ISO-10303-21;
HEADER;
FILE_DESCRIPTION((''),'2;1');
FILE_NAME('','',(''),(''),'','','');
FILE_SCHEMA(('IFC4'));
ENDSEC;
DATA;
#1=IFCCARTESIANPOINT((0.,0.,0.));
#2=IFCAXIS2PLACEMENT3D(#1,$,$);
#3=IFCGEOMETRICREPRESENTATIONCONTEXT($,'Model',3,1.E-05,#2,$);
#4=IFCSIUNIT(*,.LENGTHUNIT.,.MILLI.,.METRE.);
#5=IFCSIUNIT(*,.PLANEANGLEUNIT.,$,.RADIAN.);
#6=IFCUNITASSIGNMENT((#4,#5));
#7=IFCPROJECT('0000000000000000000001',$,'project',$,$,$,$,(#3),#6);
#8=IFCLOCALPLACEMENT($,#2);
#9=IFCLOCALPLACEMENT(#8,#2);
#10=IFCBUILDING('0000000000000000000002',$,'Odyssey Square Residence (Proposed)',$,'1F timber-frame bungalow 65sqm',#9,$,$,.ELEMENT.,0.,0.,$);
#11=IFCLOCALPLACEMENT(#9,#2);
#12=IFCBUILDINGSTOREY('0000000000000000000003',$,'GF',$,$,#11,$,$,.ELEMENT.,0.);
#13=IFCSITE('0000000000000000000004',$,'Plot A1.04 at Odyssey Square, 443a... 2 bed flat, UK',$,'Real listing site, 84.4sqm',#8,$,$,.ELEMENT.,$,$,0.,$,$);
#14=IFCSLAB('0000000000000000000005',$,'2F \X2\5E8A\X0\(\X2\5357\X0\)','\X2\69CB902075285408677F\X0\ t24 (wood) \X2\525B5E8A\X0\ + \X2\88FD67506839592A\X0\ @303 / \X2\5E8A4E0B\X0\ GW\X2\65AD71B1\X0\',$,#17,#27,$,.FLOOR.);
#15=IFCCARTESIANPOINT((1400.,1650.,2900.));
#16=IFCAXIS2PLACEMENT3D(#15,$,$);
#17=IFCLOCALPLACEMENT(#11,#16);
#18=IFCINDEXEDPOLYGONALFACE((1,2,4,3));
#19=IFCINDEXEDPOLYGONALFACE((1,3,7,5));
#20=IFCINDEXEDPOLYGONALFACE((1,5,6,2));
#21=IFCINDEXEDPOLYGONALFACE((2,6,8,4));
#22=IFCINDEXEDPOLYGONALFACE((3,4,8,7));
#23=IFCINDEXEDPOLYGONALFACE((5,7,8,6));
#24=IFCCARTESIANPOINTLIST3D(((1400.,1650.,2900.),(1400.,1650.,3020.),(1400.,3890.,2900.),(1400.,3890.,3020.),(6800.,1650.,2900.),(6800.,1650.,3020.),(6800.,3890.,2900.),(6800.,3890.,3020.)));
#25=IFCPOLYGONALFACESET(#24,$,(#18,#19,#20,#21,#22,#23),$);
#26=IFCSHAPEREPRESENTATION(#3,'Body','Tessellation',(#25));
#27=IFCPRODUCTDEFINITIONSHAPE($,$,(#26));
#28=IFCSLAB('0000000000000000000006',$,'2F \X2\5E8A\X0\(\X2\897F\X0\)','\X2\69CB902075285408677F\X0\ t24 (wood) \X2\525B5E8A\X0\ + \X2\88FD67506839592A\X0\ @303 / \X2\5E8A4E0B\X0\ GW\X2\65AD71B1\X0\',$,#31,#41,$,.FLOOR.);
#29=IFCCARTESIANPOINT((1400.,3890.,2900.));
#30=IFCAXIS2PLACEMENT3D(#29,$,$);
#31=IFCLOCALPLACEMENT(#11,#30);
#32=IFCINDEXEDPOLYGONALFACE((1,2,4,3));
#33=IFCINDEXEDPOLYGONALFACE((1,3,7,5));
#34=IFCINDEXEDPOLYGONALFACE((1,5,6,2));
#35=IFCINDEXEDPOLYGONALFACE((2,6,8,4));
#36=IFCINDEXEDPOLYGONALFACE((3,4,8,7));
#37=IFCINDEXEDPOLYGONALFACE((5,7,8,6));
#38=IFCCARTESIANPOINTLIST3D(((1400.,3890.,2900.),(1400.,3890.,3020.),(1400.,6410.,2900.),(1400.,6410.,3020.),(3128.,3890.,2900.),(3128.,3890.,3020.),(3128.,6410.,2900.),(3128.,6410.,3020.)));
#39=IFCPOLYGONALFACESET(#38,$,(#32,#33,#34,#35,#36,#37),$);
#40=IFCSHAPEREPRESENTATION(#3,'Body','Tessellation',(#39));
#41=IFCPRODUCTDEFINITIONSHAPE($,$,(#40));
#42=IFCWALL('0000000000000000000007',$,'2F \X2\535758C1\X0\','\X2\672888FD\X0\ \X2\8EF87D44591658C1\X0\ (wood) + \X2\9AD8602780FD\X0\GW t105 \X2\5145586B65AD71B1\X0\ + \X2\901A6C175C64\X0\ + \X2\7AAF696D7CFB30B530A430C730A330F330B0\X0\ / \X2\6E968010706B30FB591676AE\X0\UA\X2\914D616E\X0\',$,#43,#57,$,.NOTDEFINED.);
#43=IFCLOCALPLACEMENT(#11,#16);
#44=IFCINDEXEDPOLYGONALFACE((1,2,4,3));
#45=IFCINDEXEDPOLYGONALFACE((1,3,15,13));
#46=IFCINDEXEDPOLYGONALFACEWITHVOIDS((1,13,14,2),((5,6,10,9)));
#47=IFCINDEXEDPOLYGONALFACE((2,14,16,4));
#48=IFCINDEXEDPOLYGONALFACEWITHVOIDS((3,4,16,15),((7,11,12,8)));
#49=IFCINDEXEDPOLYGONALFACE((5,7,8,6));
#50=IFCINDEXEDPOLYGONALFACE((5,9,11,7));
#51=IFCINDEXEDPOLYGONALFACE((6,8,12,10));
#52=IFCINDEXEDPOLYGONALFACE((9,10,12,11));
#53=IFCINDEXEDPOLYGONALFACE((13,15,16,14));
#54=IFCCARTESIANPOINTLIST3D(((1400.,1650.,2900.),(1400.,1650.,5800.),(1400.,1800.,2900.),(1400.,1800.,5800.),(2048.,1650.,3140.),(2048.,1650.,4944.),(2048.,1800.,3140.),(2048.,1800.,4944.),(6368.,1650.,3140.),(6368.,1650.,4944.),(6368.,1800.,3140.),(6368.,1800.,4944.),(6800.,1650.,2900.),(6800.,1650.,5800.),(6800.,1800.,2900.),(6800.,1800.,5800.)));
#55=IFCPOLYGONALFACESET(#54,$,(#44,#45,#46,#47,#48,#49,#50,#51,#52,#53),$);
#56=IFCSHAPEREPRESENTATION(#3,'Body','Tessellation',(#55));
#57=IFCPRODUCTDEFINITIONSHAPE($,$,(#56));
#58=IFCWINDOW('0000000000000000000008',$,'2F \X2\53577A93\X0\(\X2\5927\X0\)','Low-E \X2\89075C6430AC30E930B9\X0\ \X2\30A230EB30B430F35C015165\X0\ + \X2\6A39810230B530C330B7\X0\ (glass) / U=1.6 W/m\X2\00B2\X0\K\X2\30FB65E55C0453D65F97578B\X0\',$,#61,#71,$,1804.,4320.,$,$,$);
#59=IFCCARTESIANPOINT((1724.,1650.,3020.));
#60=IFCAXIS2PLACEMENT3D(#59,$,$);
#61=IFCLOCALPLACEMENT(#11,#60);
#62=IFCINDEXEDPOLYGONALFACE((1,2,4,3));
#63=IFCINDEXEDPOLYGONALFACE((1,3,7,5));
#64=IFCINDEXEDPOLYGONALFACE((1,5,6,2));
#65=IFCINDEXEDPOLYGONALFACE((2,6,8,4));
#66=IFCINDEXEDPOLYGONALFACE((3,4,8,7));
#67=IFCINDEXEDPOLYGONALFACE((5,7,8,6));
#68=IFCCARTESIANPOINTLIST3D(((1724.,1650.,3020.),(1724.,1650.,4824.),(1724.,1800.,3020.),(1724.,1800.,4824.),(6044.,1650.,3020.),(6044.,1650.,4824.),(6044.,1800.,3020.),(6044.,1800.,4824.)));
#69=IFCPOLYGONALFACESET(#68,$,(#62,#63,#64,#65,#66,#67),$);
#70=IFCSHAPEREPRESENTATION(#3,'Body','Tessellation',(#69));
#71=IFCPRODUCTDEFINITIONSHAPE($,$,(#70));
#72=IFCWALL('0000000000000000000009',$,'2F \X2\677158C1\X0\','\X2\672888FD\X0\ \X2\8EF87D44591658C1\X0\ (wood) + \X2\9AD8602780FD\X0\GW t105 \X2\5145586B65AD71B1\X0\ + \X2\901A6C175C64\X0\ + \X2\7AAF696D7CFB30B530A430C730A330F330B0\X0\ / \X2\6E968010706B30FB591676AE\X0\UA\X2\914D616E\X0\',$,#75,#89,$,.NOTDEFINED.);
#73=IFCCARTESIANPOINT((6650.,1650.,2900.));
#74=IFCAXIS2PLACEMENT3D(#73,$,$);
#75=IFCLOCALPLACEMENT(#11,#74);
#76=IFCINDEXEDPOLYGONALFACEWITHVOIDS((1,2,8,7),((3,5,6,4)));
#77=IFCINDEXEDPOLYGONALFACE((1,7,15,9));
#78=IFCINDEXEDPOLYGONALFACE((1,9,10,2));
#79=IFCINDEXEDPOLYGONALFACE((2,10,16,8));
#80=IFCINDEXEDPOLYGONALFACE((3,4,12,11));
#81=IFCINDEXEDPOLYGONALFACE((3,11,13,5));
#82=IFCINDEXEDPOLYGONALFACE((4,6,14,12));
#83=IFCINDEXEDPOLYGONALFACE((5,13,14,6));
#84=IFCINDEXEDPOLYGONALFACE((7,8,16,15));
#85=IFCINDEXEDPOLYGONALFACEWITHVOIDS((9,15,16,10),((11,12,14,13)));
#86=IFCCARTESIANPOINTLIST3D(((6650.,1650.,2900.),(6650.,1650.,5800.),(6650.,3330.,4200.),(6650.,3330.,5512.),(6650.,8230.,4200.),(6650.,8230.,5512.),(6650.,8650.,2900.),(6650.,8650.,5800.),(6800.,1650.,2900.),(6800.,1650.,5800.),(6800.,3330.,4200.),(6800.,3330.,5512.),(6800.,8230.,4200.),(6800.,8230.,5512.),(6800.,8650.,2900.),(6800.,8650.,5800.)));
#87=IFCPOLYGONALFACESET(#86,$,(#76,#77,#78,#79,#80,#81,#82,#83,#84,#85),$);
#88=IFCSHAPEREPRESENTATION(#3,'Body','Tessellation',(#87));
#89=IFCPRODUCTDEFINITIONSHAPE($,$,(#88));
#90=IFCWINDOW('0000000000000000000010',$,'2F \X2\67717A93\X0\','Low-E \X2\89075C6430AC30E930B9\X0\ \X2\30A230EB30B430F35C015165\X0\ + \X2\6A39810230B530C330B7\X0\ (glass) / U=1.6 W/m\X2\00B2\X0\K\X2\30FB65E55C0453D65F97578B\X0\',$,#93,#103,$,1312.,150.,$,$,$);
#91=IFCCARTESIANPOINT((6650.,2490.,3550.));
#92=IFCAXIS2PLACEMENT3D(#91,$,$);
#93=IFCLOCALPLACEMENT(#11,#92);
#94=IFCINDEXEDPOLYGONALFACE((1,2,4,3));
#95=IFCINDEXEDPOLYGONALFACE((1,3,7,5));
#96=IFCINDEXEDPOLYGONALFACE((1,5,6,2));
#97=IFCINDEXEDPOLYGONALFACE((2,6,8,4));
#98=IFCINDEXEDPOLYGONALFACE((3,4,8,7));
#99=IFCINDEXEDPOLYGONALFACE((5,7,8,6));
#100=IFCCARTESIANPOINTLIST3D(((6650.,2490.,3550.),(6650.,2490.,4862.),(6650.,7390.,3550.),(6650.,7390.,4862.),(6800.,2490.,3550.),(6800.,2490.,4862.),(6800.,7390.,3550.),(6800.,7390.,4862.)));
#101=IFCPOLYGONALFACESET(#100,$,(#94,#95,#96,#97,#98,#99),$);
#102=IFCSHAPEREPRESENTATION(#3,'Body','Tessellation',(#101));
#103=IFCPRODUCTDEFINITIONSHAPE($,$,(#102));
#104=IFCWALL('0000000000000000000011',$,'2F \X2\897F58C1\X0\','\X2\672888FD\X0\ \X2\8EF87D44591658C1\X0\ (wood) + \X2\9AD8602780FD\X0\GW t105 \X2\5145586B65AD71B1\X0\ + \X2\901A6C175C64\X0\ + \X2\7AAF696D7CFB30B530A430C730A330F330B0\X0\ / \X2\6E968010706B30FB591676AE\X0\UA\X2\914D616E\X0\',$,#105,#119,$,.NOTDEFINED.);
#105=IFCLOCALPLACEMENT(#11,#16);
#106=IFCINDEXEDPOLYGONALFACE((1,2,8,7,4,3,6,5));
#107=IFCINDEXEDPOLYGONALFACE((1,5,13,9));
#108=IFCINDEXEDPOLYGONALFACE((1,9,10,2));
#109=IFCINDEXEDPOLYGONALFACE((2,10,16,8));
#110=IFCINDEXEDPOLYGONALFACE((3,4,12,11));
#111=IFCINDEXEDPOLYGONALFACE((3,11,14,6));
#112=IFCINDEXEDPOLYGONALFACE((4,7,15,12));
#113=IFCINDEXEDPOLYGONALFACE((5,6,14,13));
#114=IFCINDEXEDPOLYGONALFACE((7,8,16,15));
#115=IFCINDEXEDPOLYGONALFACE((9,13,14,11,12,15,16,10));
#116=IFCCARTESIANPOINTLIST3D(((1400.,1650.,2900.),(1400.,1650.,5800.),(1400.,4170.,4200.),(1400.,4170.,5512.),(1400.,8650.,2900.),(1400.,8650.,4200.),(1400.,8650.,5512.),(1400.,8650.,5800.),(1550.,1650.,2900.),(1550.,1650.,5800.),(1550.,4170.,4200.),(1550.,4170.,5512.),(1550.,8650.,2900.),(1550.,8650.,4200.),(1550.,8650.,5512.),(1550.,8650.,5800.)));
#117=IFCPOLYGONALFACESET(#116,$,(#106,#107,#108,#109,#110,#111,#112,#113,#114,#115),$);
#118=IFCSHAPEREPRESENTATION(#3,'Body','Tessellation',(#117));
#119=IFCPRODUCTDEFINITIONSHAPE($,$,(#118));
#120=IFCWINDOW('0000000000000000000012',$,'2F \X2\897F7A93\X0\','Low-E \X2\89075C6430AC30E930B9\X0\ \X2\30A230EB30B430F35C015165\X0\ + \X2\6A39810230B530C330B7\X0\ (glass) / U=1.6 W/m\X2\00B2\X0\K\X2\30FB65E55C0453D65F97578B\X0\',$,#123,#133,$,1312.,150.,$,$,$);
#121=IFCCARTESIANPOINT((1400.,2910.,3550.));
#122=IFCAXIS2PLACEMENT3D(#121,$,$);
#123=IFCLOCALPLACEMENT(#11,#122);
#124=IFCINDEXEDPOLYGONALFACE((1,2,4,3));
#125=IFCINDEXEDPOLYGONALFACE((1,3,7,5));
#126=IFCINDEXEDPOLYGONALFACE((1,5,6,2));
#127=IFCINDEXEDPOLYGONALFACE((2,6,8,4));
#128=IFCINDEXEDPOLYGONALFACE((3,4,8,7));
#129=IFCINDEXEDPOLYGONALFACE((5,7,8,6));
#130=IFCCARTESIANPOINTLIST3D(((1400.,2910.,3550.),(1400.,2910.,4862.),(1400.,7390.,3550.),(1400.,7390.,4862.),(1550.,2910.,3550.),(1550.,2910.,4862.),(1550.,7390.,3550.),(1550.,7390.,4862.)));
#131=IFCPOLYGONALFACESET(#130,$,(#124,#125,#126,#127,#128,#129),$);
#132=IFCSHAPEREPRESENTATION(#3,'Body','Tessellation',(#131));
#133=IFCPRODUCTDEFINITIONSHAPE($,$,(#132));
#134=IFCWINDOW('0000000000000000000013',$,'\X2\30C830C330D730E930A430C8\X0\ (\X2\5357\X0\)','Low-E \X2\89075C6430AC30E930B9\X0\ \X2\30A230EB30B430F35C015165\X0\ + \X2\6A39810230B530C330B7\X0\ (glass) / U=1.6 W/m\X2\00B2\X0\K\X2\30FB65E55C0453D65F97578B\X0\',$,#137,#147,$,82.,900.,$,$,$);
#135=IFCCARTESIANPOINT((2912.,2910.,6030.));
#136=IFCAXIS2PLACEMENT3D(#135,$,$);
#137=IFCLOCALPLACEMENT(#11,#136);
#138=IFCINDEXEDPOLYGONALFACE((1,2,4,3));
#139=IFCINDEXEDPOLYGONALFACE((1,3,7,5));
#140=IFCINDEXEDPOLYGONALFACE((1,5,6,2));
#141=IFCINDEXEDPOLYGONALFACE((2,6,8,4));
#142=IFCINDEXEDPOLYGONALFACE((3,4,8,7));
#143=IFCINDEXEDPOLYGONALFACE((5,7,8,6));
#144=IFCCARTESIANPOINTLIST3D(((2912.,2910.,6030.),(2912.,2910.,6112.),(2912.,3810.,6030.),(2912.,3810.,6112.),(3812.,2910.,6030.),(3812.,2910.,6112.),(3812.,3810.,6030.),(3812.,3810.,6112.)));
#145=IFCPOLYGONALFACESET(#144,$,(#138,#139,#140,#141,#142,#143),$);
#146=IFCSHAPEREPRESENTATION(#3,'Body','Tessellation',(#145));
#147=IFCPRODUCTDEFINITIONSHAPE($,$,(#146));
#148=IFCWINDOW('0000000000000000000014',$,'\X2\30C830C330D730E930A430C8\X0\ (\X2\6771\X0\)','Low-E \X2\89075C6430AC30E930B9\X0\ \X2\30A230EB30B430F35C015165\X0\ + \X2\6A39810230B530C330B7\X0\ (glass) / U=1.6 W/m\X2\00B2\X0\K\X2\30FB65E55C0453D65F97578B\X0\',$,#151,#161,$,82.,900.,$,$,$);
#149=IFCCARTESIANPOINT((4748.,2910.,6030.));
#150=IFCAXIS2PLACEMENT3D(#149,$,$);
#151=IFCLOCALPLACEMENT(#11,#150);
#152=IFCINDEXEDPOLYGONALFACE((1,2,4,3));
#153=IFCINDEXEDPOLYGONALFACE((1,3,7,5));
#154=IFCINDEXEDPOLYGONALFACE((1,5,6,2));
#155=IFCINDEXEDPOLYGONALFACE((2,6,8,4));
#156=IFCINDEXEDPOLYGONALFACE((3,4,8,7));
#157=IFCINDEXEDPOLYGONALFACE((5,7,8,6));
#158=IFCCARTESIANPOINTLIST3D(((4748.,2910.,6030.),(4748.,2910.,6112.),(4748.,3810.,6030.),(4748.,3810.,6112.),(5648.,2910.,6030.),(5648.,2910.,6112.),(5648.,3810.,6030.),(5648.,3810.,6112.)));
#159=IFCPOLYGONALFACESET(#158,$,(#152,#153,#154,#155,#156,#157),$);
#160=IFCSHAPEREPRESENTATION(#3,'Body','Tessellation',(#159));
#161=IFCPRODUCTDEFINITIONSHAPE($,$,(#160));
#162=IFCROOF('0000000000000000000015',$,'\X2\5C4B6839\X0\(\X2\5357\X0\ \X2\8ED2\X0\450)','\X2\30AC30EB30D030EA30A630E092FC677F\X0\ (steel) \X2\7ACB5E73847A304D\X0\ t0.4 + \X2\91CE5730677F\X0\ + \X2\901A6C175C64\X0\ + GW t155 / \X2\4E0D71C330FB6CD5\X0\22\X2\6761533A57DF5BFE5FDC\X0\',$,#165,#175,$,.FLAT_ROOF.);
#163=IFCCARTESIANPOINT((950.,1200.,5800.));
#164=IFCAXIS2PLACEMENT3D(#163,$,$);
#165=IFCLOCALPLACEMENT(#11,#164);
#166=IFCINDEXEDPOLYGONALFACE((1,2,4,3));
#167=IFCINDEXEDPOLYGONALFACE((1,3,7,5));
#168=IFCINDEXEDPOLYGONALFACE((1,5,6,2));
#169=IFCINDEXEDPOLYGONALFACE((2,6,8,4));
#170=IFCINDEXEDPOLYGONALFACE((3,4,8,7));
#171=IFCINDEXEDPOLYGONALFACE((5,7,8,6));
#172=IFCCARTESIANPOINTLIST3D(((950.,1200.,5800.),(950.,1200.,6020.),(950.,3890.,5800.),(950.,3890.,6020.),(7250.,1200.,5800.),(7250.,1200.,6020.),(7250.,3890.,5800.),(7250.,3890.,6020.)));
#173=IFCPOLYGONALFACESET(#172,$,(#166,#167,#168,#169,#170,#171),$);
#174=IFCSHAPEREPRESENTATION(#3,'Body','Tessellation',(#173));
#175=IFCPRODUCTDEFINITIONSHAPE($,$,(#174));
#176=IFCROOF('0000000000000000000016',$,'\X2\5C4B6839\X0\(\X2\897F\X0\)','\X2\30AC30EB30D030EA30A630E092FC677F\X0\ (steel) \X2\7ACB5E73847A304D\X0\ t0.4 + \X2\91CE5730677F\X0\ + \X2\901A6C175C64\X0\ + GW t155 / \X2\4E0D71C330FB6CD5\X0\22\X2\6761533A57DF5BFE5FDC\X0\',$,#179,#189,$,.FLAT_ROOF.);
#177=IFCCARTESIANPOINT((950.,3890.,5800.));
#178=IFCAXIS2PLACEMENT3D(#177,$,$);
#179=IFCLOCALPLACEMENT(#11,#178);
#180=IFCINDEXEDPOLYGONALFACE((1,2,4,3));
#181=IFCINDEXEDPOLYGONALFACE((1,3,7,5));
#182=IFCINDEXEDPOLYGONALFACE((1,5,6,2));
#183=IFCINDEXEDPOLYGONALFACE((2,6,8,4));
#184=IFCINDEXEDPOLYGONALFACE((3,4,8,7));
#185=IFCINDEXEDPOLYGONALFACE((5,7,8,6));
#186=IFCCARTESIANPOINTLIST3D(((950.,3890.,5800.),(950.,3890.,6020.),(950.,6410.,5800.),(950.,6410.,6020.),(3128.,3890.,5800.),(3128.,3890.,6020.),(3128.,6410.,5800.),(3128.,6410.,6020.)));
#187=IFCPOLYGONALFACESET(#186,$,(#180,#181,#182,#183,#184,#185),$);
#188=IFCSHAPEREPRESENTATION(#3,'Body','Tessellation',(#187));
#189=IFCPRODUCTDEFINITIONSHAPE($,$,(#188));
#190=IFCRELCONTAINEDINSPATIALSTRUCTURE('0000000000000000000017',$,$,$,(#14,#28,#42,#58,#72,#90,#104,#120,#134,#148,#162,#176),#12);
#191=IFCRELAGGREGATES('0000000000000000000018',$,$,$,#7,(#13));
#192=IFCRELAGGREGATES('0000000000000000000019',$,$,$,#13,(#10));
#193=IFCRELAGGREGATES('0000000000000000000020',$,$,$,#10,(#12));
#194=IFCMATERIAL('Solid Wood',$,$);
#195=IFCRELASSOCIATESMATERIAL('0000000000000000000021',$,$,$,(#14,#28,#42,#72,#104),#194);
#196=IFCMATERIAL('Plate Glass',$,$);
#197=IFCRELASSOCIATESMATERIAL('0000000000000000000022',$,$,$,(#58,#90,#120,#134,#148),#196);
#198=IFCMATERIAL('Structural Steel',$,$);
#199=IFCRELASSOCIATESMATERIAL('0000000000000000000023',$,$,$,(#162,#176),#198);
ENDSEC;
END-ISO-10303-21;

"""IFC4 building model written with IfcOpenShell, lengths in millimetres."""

from ifc_helpers import new_model, si_unit, frame, frame_2d, origin, place, context, project, spatial, rectangle, extrude, material, element, fill, save


model = new_model("IFC4")

# Units and contexts
model_context = context("Model", 3, precision=1e-05, world=origin())
ifc_project = project(units=[si_unit("LENGTHUNIT", "METRE", prefix="MILLI"), si_unit("PLANEANGLEUNIT", "RADIAN")], contexts=[model_context])

# Site, building, storey
site_placement = place(None, origin())
site = spatial("IfcSite", under=ifc_project, at=site_placement, Name="Plot A1.04 at Odyssey Square, 443a... 2 bed flat, UK", ObjectType="Real listing site, 84.4sqm", CompositionType="ELEMENT", RefElevation=0.0)
building_placement = place(site_placement, origin())
building = spatial("IfcBuilding", under=site, at=building_placement, Name="Odyssey Square Residence (Proposed)", ObjectType="1F timber-frame bungalow 65sqm", CompositionType="ELEMENT", ElevationOfRefHeight=0.0, ElevationOfTerrain=0.0)
storey_placement = place(building_placement, origin())
storey = spatial("IfcBuildingStorey", under=building, at=storey_placement, Name="GF", CompositionType="ELEMENT", Elevation=0.0)

# Slabs
ifc_material_1 = material(Name="Solid Wood")
slab_1_placement = place(storey_placement, frame((1400.0, 1650.0, 2900.0)))
element("IfcSlab", 1, at=slab_1_placement, inside=storey, material=ifc_material_1, Name="2F 床(南)", Description="構造用合板 t24 (wood) 剛床 + 製材根太 @303 / 床下 GW断熱", PredefinedType="FLOOR", context=model_context, shape_type="SweptSolid", body=[
    extrude(rectangle(XDim=5400.0, YDim=2240.0, at=frame_2d((2700.0, 1120.0))), frame((1400.0, 1650.0, 2900.0)), (0.0, 0.0, 1.0), 120.0),
])
slab_2_placement = place(storey_placement, frame((1400.0, 3890.0, 2900.0)))
element("IfcSlab", 2, at=slab_2_placement, inside=storey, material=ifc_material_1, Name="2F 床(西)", Description="構造用合板 t24 (wood) 剛床 + 製材根太 @303 / 床下 GW断熱", PredefinedType="FLOOR", context=model_context, shape_type="SweptSolid", body=[
    extrude(rectangle(XDim=1728.0, YDim=2520.0, at=frame_2d((864.0, 1260.0))), frame((1400.0, 3890.0, 2900.0)), (0.0, 0.0, 1.0), 120.0),
])

# Walls, openings, windows
wall_1_placement = place(storey_placement, frame((1400.0, 1650.0, 2900.0)))
wall_1 = element("IfcWall", 3, at=wall_1_placement, inside=storey, material=ifc_material_1, Name="2F 南壁", Description="木製 軸組外壁 (wood) + 高性能GW t105 充填断熱 + 通気層 + 窯業系サイディング / 準耐火・外皮UA配慮", PredefinedType="NOTDEFINED", context=model_context, shape_type="SweptSolid", body=[
    extrude(rectangle(XDim=5400.0, YDim=150.0, at=frame_2d((2700.0, 75.0))), frame((1400.0, 1650.0, 2900.0)), (0.0, 0.0, 1.0), 2900.0),
])
opening_1_placement = place(storey_placement, frame((1724.0, 1650.0, 3020.0)))
opening_1 = element("IfcOpeningElement", 4, at=opening_1_placement, cuts=wall_1, PredefinedType="NOTDEFINED", context=model_context, shape_type="SweptSolid", body=[
    extrude(rectangle(XDim=4320.0, YDim=150.0, at=frame_2d((2160.0, 75.0))), frame((1724.0, 1650.0, 3020.0)), (0.0, 0.0, 1.0), 1804.0),
])
ifc_material_2 = material(Name="Plate Glass")
window_1_placement = place(storey_placement, frame((1724.0, 1650.0, 3020.0)))
window_1 = element("IfcWindow", 5, at=window_1_placement, inside=storey, material=ifc_material_2, Name="2F 南窓(大)", Description="Low-E 複層ガラス アルゴン封入 + 樹脂サッシ (glass) / U=1.6 W/m²K・日射取得型", OverallHeight=1804.0, OverallWidth=4320.0, context=model_context, shape_type="SweptSolid", body=[
    extrude(rectangle(XDim=4320.0, YDim=150.0, at=frame_2d((2160.0, 75.0))), frame((1724.0, 1650.0, 3020.0)), (0.0, 0.0, 1.0), 1804.0),
])
fill(opening_1, window_1)
wall_2_placement = place(storey_placement, frame((6650.0, 1650.0, 2900.0)))
wall_2 = element("IfcWall", 6, at=wall_2_placement, inside=storey, material=ifc_material_1, Name="2F 東壁", Description="木製 軸組外壁 (wood) + 高性能GW t105 充填断熱 + 通気層 + 窯業系サイディング / 準耐火・外皮UA配慮", PredefinedType="NOTDEFINED", context=model_context, shape_type="SweptSolid", body=[
    extrude(rectangle(XDim=150.0, YDim=7000.0, at=frame_2d((75.0, 3500.0))), frame((6650.0, 1650.0, 2900.0)), (0.0, 0.0, 1.0), 2900.0),
])
opening_2_placement = place(storey_placement, frame((6650.0, 2490.0, 3550.0)))
opening_2 = element("IfcOpeningElement", 7, at=opening_2_placement, cuts=wall_2, PredefinedType="NOTDEFINED", context=model_context, shape_type="SweptSolid", body=[
    extrude(rectangle(XDim=150.0, YDim=4900.0, at=frame_2d((75.0, 2450.0))), frame((6650.0, 2490.0, 3550.0)), (0.0, 0.0, 1.0), 1312.0),
])
window_2_placement = place(storey_placement, frame((6650.0, 2490.0, 3550.0)))
window_2 = element("IfcWindow", 8, at=window_2_placement, inside=storey, material=ifc_material_2, Name="2F 東窓", Description="Low-E 複層ガラス アルゴン封入 + 樹脂サッシ (glass) / U=1.6 W/m²K・日射取得型", OverallHeight=1312.0, OverallWidth=150.0, context=model_context, shape_type="SweptSolid", body=[
    extrude(rectangle(XDim=150.0, YDim=4900.0, at=frame_2d((75.0, 2450.0))), frame((6650.0, 2490.0, 3550.0)), (0.0, 0.0, 1.0), 1312.0),
])
fill(opening_2, window_2)
wall_3_placement = place(storey_placement, frame((1400.0, 1650.0, 2900.0)))
wall_3 = element("IfcWall", 9, at=wall_3_placement, inside=storey, material=ifc_material_1, Name="2F 西壁", Description="木製 軸組外壁 (wood) + 高性能GW t105 充填断熱 + 通気層 + 窯業系サイディング / 準耐火・外皮UA配慮", PredefinedType="NOTDEFINED", context=model_context, shape_type="SweptSolid", body=[
    extrude(rectangle(XDim=150.0, YDim=7000.0, at=frame_2d((75.0, 3500.0))), frame((1400.0, 1650.0, 2900.0)), (0.0, 0.0, 1.0), 2900.0),
])
opening_3_placement = place(storey_placement, frame((1400.0, 2910.0, 3550.0)))
opening_3 = element("IfcOpeningElement", 10, at=opening_3_placement, cuts=wall_3, PredefinedType="NOTDEFINED", context=model_context, shape_type="SweptSolid", body=[
    extrude(rectangle(XDim=150.0, YDim=4480.0, at=frame_2d((75.0, 2240.0))), frame((1400.0, 2910.0, 3550.0)), (0.0, 0.0, 1.0), 1312.0),
])
window_3_placement = place(storey_placement, frame((1400.0, 2910.0, 3550.0)))
window_3 = element("IfcWindow", 11, at=window_3_placement, inside=storey, material=ifc_material_2, Name="2F 西窓", Description="Low-E 複層ガラス アルゴン封入 + 樹脂サッシ (glass) / U=1.6 W/m²K・日射取得型", OverallHeight=1312.0, OverallWidth=150.0, context=model_context, shape_type="SweptSolid", body=[
    extrude(rectangle(XDim=150.0, YDim=4480.0, at=frame_2d((75.0, 2240.0))), frame((1400.0, 2910.0, 3550.0)), (0.0, 0.0, 1.0), 1312.0),
])
fill(opening_3, window_3)

# Windows
window_4_placement = place(storey_placement, frame((2912.0, 2910.0, 6030.0)))
element("IfcWindow", 12, at=window_4_placement, inside=storey, material=ifc_material_2, Name="トップライト (南)", Description="Low-E 複層ガラス アルゴン封入 + 樹脂サッシ (glass) / U=1.6 W/m²K・日射取得型", OverallHeight=82.0, OverallWidth=900.0, context=model_context, shape_type="SweptSolid", body=[
    extrude(rectangle(XDim=900.0, YDim=900.0, at=frame_2d((450.0, 450.0))), frame((2912.0, 2910.0, 6030.0)), (0.0, 0.0, 1.0), 82.0),
])
window_5_placement = place(storey_placement, frame((4748.0, 2910.0, 6030.0)))
element("IfcWindow", 13, at=window_5_placement, inside=storey, material=ifc_material_2, Name="トップライト (東)", Description="Low-E 複層ガラス アルゴン封入 + 樹脂サッシ (glass) / U=1.6 W/m²K・日射取得型", OverallHeight=82.0, OverallWidth=900.0, context=model_context, shape_type="SweptSolid", body=[
    extrude(rectangle(XDim=900.0, YDim=900.0, at=frame_2d((450.0, 450.0))), frame((4748.0, 2910.0, 6030.0)), (0.0, 0.0, 1.0), 82.0),
])

# Roofs
ifc_material_3 = material(Name="Structural Steel")
roof_1_placement = place(storey_placement, frame((950.0, 1200.0, 5800.0)))
element("IfcRoof", 14, at=roof_1_placement, inside=storey, material=ifc_material_3, Name="屋根(南 軒450)", Description="ガルバリウム鋼板 (steel) 立平葺き t0.4 + 野地板 + 通気層 + GW t155 / 不燃・法22条区域対応", PredefinedType="FLAT_ROOF", context=model_context, shape_type="SweptSolid", body=[
    extrude(rectangle(XDim=6300.0, YDim=2690.0, at=frame_2d((3150.0, 1345.0))), frame((950.0, 1200.0, 5800.0)), (0.0, 0.0, 1.0), 220.0),
])
roof_2_placement = place(storey_placement, frame((950.0, 3890.0, 5800.0)))
element("IfcRoof", 15, at=roof_2_placement, inside=storey, material=ifc_material_3, Name="屋根(西)", Description="ガルバリウム鋼板 (steel) 立平葺き t0.4 + 野地板 + 通気層 + GW t155 / 不燃・法22条区域対応", PredefinedType="FLAT_ROOF", context=model_context, shape_type="SweptSolid", body=[
    extrude(rectangle(XDim=2178.0, YDim=2520.0, at=frame_2d((1089.0, 1260.0))), frame((950.0, 3890.0, 5800.0)), (0.0, 0.0, 1.0), 220.0),
])

save(model, "model.ifc")
